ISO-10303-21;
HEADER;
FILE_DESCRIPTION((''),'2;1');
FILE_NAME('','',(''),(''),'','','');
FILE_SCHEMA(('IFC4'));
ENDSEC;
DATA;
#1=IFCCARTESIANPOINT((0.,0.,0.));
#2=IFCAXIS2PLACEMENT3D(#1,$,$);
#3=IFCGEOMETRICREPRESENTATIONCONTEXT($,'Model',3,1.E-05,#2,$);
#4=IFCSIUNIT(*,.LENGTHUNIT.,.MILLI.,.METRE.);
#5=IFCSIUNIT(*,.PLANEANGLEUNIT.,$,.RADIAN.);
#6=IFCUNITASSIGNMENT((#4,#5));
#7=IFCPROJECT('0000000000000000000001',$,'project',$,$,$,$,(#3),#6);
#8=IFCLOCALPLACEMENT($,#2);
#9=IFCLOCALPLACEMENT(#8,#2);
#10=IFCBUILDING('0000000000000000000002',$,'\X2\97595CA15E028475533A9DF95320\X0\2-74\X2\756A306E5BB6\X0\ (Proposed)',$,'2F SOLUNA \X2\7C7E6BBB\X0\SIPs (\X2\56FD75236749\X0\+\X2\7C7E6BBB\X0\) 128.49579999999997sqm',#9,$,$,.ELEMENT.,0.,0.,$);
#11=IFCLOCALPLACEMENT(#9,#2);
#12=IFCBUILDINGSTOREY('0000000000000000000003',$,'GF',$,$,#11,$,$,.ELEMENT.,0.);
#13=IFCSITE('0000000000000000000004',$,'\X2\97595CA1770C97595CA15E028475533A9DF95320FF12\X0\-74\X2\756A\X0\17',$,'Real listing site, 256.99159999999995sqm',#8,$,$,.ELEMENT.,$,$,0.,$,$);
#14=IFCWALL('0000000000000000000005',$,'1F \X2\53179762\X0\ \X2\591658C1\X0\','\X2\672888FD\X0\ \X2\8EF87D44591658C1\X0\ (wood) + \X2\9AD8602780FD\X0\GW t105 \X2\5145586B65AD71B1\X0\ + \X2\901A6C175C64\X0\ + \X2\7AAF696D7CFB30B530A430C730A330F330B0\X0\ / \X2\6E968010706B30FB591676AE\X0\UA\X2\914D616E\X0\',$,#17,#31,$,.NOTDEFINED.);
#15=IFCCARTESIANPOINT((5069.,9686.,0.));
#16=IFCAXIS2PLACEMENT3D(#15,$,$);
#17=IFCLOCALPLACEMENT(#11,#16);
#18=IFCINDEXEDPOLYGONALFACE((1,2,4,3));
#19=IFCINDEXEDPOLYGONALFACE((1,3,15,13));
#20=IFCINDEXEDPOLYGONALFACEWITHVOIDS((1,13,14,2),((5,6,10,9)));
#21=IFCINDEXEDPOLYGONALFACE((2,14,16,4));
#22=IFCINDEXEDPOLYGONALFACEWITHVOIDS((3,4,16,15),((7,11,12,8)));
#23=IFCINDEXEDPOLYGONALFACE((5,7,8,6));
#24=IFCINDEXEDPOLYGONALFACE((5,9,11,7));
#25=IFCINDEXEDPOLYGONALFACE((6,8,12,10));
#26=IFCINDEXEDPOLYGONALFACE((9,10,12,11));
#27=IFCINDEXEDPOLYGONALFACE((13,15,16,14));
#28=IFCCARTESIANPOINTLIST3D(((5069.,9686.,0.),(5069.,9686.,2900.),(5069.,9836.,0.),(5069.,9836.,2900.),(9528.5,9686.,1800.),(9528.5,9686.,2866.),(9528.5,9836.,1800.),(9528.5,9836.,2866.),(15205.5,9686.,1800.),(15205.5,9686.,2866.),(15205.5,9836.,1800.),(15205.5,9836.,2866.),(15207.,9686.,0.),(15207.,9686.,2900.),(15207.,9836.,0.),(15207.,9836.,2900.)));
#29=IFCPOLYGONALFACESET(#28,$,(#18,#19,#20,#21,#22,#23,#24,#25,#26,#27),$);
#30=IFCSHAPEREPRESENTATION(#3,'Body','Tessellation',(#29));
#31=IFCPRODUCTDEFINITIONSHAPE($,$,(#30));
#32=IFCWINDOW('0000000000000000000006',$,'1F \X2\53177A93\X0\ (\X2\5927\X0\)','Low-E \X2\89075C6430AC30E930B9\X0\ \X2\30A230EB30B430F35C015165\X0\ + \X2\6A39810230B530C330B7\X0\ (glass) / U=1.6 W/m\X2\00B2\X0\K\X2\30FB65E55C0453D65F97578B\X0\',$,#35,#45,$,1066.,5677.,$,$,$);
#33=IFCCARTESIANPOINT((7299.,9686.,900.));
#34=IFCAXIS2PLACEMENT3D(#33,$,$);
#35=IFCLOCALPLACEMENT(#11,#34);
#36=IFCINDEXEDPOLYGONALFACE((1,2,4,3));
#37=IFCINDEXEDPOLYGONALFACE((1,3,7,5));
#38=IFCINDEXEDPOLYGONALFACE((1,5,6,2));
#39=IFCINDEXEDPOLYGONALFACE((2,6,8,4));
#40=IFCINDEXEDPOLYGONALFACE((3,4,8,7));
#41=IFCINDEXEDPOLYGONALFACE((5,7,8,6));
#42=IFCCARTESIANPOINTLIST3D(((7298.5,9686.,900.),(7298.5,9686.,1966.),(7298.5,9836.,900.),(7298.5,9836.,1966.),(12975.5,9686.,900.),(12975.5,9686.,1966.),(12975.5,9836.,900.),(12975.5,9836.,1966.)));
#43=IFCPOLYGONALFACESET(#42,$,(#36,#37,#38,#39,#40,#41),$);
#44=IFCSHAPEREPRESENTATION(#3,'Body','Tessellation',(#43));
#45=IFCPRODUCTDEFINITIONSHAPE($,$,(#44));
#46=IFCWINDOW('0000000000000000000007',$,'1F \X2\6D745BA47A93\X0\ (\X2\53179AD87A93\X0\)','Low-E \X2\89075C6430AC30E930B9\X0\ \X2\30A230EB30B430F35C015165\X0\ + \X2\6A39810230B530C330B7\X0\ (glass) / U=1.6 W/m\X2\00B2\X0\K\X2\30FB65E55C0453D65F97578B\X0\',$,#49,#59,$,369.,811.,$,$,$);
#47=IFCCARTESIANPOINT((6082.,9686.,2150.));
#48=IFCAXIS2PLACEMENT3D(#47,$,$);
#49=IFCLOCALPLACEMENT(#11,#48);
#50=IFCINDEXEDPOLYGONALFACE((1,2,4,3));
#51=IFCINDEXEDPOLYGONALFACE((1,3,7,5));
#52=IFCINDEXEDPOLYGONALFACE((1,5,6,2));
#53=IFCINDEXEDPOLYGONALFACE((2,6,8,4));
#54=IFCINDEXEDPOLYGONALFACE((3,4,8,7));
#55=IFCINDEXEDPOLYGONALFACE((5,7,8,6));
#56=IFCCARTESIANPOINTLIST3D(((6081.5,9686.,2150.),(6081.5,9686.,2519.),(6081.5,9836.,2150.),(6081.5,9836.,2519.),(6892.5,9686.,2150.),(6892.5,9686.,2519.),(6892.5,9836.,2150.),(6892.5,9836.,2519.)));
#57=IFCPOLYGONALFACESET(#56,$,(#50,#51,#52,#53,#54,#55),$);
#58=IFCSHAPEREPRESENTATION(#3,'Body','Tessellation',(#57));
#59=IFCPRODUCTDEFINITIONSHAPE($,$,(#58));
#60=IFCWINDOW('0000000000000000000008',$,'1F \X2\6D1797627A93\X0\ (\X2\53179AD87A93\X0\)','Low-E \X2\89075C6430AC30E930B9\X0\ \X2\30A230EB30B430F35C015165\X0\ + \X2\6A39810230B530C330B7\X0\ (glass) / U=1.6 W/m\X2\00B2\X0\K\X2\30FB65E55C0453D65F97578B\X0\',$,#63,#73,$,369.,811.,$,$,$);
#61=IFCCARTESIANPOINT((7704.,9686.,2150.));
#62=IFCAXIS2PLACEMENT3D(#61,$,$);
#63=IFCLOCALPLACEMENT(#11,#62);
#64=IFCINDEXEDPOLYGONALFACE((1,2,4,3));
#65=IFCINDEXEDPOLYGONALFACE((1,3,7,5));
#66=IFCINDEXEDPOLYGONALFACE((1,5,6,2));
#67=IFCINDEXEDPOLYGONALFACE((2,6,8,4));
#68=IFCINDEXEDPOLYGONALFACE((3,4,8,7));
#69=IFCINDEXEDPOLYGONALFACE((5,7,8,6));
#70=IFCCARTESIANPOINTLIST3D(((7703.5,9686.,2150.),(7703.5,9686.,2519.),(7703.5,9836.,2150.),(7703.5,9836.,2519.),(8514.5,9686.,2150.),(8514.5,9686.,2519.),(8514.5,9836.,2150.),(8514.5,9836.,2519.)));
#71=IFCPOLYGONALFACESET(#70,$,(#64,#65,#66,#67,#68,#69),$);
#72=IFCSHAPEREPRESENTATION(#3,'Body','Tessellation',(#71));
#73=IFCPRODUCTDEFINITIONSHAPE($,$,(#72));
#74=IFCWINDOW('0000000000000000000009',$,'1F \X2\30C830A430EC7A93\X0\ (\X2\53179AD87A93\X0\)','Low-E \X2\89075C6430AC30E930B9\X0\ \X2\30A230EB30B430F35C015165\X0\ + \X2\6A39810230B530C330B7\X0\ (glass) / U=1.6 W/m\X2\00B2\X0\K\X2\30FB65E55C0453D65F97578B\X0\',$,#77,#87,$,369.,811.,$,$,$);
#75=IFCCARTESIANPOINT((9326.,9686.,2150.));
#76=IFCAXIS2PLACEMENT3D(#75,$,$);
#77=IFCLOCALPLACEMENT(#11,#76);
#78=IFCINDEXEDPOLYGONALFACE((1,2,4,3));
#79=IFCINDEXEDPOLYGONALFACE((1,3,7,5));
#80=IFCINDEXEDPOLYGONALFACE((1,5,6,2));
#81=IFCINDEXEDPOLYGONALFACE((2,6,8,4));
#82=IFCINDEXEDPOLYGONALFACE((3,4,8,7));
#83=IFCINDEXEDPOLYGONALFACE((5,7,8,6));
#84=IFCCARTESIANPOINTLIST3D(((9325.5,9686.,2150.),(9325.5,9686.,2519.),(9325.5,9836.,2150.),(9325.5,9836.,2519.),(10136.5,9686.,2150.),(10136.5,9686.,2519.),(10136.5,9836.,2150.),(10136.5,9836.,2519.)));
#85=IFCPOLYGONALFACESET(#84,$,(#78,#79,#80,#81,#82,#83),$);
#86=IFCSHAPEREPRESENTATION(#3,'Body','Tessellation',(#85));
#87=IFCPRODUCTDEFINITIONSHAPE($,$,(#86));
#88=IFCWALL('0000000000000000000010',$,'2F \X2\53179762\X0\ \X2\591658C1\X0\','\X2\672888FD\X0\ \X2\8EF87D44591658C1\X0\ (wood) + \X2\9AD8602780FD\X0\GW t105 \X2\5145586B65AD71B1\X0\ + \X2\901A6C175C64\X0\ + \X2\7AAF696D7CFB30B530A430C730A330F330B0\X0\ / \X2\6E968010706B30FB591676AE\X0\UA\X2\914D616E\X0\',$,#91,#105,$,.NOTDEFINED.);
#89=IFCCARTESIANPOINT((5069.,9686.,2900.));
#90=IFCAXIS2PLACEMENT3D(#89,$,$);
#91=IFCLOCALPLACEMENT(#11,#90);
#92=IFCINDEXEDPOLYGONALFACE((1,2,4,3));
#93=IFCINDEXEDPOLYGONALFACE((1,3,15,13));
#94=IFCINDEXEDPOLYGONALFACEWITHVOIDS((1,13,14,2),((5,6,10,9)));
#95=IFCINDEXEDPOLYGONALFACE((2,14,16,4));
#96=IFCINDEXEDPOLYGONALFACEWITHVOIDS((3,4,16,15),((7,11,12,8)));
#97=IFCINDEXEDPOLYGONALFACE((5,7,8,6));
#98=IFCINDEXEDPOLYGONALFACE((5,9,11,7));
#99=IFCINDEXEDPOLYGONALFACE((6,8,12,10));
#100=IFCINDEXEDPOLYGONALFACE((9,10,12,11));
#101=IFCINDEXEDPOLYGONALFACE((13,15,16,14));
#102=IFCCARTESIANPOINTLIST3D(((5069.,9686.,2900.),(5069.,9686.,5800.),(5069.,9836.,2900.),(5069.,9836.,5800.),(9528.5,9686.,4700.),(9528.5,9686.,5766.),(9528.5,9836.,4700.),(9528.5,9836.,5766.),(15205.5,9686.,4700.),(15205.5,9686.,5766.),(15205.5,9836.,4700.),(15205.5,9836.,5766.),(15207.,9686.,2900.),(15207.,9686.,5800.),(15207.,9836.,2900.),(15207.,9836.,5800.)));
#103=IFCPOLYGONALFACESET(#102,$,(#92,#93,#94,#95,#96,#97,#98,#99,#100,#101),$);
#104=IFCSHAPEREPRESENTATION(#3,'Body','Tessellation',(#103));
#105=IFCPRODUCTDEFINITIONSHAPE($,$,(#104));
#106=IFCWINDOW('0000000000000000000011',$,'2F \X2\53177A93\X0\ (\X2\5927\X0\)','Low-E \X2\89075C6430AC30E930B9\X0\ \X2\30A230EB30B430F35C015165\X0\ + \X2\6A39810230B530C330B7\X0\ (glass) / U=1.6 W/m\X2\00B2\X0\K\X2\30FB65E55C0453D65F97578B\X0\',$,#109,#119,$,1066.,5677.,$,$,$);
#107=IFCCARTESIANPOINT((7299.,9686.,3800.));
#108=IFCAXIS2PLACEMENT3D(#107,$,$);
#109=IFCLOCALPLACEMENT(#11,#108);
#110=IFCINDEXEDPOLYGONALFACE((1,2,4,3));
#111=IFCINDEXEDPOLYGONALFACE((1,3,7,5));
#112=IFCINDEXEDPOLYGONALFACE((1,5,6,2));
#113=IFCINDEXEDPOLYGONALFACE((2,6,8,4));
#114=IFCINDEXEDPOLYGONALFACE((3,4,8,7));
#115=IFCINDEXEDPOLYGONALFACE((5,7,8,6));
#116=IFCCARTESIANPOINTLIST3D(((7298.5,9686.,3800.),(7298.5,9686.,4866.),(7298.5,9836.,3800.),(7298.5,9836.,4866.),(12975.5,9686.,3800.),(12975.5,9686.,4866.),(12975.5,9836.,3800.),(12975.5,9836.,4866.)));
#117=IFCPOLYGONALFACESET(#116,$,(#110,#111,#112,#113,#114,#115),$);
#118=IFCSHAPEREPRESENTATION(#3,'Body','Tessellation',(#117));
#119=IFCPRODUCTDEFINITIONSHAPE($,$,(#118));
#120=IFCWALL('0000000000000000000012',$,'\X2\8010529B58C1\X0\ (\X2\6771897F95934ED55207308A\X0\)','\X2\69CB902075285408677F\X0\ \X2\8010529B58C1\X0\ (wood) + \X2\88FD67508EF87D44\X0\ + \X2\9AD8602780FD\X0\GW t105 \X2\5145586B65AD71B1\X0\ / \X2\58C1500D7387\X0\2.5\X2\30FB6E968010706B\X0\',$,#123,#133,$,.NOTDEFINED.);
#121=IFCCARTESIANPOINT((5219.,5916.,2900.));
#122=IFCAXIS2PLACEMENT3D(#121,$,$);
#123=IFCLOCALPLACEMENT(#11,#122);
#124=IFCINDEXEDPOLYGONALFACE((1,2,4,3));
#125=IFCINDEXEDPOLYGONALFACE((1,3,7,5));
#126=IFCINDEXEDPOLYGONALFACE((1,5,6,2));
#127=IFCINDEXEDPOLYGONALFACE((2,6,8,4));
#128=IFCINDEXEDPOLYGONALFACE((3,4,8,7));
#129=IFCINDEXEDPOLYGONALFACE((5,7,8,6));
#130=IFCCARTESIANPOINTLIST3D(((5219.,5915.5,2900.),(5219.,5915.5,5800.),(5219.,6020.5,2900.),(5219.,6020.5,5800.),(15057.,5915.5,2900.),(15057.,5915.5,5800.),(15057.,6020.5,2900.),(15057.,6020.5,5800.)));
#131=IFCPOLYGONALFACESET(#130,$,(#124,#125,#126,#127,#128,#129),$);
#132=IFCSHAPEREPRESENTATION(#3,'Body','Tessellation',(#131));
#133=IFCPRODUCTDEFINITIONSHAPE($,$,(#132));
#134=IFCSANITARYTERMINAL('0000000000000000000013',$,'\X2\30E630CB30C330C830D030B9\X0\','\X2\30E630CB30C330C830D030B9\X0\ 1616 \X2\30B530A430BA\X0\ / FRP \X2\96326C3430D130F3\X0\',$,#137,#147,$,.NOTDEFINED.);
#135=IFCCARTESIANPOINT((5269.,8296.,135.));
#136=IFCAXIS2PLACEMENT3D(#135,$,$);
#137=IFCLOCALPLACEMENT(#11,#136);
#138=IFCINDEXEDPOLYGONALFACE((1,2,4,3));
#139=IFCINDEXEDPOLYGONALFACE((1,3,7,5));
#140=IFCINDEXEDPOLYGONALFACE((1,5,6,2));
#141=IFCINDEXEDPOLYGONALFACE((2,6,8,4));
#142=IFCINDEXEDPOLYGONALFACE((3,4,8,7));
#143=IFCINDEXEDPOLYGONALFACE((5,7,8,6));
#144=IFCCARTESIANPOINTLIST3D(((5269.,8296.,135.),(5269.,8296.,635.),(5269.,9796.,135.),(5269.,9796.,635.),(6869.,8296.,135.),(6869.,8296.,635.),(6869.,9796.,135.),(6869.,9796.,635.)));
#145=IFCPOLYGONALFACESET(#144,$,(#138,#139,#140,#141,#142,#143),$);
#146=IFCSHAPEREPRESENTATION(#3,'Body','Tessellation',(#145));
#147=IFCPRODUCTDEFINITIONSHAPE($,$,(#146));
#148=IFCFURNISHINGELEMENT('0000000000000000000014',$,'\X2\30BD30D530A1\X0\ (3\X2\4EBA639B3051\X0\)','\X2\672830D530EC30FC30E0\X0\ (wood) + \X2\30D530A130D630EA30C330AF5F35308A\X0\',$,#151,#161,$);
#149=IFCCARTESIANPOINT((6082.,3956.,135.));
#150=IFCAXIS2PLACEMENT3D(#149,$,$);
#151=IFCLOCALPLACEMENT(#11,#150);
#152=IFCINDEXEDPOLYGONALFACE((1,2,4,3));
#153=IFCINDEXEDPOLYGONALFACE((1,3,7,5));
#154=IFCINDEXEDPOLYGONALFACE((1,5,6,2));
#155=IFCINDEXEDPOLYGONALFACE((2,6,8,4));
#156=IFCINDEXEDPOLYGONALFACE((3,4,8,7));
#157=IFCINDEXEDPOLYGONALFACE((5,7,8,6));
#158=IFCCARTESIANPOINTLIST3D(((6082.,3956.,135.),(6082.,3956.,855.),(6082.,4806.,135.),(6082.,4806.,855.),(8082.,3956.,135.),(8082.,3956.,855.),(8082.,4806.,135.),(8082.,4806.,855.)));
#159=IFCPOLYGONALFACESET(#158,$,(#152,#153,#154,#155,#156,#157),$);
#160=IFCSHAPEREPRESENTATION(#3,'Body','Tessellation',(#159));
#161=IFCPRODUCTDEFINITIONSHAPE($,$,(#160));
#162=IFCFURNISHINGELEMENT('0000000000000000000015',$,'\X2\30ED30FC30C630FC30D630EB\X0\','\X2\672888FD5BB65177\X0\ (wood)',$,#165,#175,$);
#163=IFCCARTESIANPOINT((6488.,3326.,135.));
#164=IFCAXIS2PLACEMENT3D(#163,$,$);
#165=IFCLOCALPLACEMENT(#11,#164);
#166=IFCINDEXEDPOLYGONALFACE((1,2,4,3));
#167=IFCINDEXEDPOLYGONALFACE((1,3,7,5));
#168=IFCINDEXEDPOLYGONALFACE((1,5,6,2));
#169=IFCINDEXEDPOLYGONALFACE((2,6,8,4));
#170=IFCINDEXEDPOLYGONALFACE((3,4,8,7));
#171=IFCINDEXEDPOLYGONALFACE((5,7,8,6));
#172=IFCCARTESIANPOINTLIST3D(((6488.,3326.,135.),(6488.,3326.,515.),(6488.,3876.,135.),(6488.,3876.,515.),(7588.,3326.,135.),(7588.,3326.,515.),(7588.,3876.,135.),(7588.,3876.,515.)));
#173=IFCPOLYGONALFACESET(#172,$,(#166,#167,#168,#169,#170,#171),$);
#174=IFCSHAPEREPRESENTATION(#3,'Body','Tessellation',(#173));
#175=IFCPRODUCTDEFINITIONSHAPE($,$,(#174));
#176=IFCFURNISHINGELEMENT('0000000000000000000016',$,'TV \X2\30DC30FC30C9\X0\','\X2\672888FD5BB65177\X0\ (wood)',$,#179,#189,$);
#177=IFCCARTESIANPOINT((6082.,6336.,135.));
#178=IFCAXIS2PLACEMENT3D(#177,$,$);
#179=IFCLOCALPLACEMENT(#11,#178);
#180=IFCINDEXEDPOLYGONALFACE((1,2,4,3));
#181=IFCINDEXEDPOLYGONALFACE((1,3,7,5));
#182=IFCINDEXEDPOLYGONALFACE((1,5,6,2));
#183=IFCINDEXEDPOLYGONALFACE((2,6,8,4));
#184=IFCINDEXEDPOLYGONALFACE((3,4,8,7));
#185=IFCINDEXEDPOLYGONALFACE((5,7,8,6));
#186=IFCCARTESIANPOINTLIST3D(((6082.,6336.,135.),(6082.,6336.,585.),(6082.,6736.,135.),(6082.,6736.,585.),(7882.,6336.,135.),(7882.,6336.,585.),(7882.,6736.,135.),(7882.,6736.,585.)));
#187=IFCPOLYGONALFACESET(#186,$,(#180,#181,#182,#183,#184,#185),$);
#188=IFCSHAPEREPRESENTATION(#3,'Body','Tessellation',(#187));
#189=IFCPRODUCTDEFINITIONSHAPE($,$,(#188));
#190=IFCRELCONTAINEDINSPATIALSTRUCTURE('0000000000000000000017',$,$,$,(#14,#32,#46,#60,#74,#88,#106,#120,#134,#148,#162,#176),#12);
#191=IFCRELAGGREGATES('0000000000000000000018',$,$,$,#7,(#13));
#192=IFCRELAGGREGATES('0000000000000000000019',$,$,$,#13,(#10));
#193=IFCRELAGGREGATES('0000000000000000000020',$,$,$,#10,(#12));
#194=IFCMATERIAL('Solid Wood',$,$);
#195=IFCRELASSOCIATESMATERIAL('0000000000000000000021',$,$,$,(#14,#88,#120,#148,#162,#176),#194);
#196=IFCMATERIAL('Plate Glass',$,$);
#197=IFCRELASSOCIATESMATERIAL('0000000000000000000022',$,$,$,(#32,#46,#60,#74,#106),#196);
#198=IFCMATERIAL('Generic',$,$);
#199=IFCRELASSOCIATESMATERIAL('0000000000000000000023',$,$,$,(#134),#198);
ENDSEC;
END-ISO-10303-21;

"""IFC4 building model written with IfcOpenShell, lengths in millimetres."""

from ifc_helpers import new_model, si_unit, frame, frame_2d, origin, place, context, project, spatial, rectangle, extrude, material, element, fill, save


model = new_model("IFC4")

# Units and contexts
model_context = context("Model", 3, precision=1e-05, world=origin())
ifc_project = project(units=[si_unit("LENGTHUNIT", "METRE", prefix="MILLI"), si_unit("PLANEANGLEUNIT", "RADIAN")], contexts=[model_context])

# Site, building, storey
site_placement = place(None, origin())
site = spatial("IfcSite", under=ifc_project, at=site_placement, Name="静岡県静岡市葵区鷹匠２-74番17", ObjectType="Real listing site, 256.99159999999995sqm", CompositionType="ELEMENT", RefElevation=0.0)
building_placement = place(site_placement, origin())
building = spatial("IfcBuilding", under=site, at=building_placement, Name="静岡市葵区鷹匠2-74番の家 (Proposed)", ObjectType="2F SOLUNA 籾殻SIPs (国産杉+籾殻) 128.49579999999997sqm", CompositionType="ELEMENT", ElevationOfRefHeight=0.0, ElevationOfTerrain=0.0)
storey_placement = place(building_placement, origin())
storey = spatial("IfcBuildingStorey", under=building, at=storey_placement, Name="GF", CompositionType="ELEMENT", Elevation=0.0)

# Wall, openings, windows
ifc_material_1 = material(Name="Solid Wood")
wall_1_placement = place(storey_placement, frame((5069.0, 9686.0, 0.0)))
wall_1 = element("IfcWall", 1, at=wall_1_placement, inside=storey, material=ifc_material_1, Name="1F 北面 外壁", Description="木製 軸組外壁 (wood) + 高性能GW t105 充填断熱 + 通気層 + 窯業系サイディング / 準耐火・外皮UA配慮", PredefinedType="NOTDEFINED", context=model_context, shape_type="SweptSolid", body=[
    extrude(rectangle(XDim=10138.0, YDim=150.0, at=frame_2d((5069.0, 75.0))), frame((5069.0, 9686.0, 0.0)), (0.0, 0.0, 1.0), 2900.0),
])
opening_1_placement = place(storey_placement, frame((7299.0, 9686.0, 900.0)))
opening_1 = element("IfcOpeningElement", 2, at=opening_1_placement, cuts=wall_1, PredefinedType="NOTDEFINED", context=model_context, shape_type="SweptSolid", body=[
    extrude(rectangle(XDim=5677.0, YDim=150.0, at=frame_2d((2838.0, 75.0))), frame((7299.0, 9686.0, 900.0)), (0.0, 0.0, 1.0), 1066.0),
])
opening_2_placement = place(storey_placement, frame((6082.0, 9686.0, 2150.0)))
opening_2 = element("IfcOpeningElement", 3, at=opening_2_placement, cuts=wall_1, PredefinedType="NOTDEFINED", context=model_context, shape_type="SweptSolid", body=[
    extrude(rectangle(XDim=811.0, YDim=150.0, at=frame_2d((405.0, 75.0))), frame((6082.0, 9686.0, 2150.0)), (0.0, 0.0, 1.0), 369.0),
])
opening_3_placement = place(storey_placement, frame((7704.0, 9686.0, 2150.0)))
opening_3 = element("IfcOpeningElement", 4, at=opening_3_placement, cuts=wall_1, PredefinedType="NOTDEFINED", context=model_context, shape_type="SweptSolid", body=[
    extrude(rectangle(XDim=811.0, YDim=150.0, at=frame_2d((405.0, 75.0))), frame((7704.0, 9686.0, 2150.0)), (0.0, 0.0, 1.0), 369.0),
])
opening_4_placement = place(storey_placement, frame((9326.0, 9686.0, 2150.0)))
opening_4 = element("IfcOpeningElement", 5, at=opening_4_placement, cuts=wall_1, PredefinedType="NOTDEFINED", context=model_context, shape_type="SweptSolid", body=[
    extrude(rectangle(XDim=811.0, YDim=150.0, at=frame_2d((405.0, 75.0))), frame((9326.0, 9686.0, 2150.0)), (0.0, 0.0, 1.0), 369.0),
])
ifc_material_2 = material(Name="Plate Glass")
window_1_placement = place(storey_placement, frame((7299.0, 9686.0, 900.0)))
window_1 = element("IfcWindow", 6, at=window_1_placement, inside=storey, material=ifc_material_2, Name="1F 北窓 (大)", Description="Low-E 複層ガラス アルゴン封入 + 樹脂サッシ (glass) / U=1.6 W/m²K・日射取得型", OverallHeight=1066.0, OverallWidth=5677.0, context=model_context, shape_type="SweptSolid", body=[
    extrude(rectangle(XDim=5677.0, YDim=150.0, at=frame_2d((2838.0, 75.0))), frame((7299.0, 9686.0, 900.0)), (0.0, 0.0, 1.0), 1066.0),
])
fill(opening_1, window_1)
window_2_placement = place(storey_placement, frame((6082.0, 9686.0, 2150.0)))
window_2 = element("IfcWindow", 7, at=window_2_placement, inside=storey, material=ifc_material_2, Name="1F 浴室窓 (北高窓)", Description="Low-E 複層ガラス アルゴン封入 + 樹脂サッシ (glass) / U=1.6 W/m²K・日射取得型", OverallHeight=369.0, OverallWidth=811.0, context=model_context, shape_type="SweptSolid", body=[
    extrude(rectangle(XDim=811.0, YDim=150.0, at=frame_2d((405.0, 75.0))), frame((6082.0, 9686.0, 2150.0)), (0.0, 0.0, 1.0), 369.0),
])
fill(opening_2, window_2)
window_3_placement = place(storey_placement, frame((7704.0, 9686.0, 2150.0)))
window_3 = element("IfcWindow", 8, at=window_3_placement, inside=storey, material=ifc_material_2, Name="1F 洗面窓 (北高窓)", Description="Low-E 複層ガラス アルゴン封入 + 樹脂サッシ (glass) / U=1.6 W/m²K・日射取得型", OverallHeight=369.0, OverallWidth=811.0, context=model_context, shape_type="SweptSolid", body=[
    extrude(rectangle(XDim=811.0, YDim=150.0, at=frame_2d((405.0, 75.0))), frame((7704.0, 9686.0, 2150.0)), (0.0, 0.0, 1.0), 369.0),
])
fill(opening_3, window_3)
window_4_placement = place(storey_placement, frame((9326.0, 9686.0, 2150.0)))
window_4 = element("IfcWindow", 9, at=window_4_placement, inside=storey, material=ifc_material_2, Name="1F トイレ窓 (北高窓)", Description="Low-E 複層ガラス アルゴン封入 + 樹脂サッシ (glass) / U=1.6 W/m²K・日射取得型", OverallHeight=369.0, OverallWidth=811.0, context=model_context, shape_type="SweptSolid", body=[
    extrude(rectangle(XDim=811.0, YDim=150.0, at=frame_2d((405.0, 75.0))), frame((9326.0, 9686.0, 2150.0)), (0.0, 0.0, 1.0), 369.0),
])
fill(opening_4, window_4)

# Wall, opening, window
wall_2_placement = place(storey_placement, frame((5069.0, 9686.0, 2900.0)))
wall_2 = element("IfcWall", 10, at=wall_2_placement, inside=storey, material=ifc_material_1, Name="2F 北面 外壁", Description="木製 軸組外壁 (wood) + 高性能GW t105 充填断熱 + 通気層 + 窯業系サイディング / 準耐火・外皮UA配慮", PredefinedType="NOTDEFINED", context=model_context, shape_type="SweptSolid", body=[
    extrude(rectangle(XDim=10138.0, YDim=150.0, at=frame_2d((5069.0, 75.0))), frame((5069.0, 9686.0, 2900.0)), (0.0, 0.0, 1.0), 2900.0),
])
opening_5_placement = place(storey_placement, frame((7299.0, 9686.0, 3800.0)))
opening_5 = element("IfcOpeningElement", 11, at=opening_5_placement, cuts=wall_2, PredefinedType="NOTDEFINED", context=model_context, shape_type="SweptSolid", body=[
    extrude(rectangle(XDim=5677.0, YDim=150.0, at=frame_2d((2838.0, 75.0))), frame((7299.0, 9686.0, 3800.0)), (0.0, 0.0, 1.0), 1066.0),
])
window_5_placement = place(storey_placement, frame((7299.0, 9686.0, 3800.0)))
window_5 = element("IfcWindow", 12, at=window_5_placement, inside=storey, material=ifc_material_2, Name="2F 北窓 (大)", Description="Low-E 複層ガラス アルゴン封入 + 樹脂サッシ (glass) / U=1.6 W/m²K・日射取得型", OverallHeight=1066.0, OverallWidth=5677.0, context=model_context, shape_type="SweptSolid", body=[
    extrude(rectangle(XDim=5677.0, YDim=150.0, at=frame_2d((2838.0, 75.0))), frame((7299.0, 9686.0, 3800.0)), (0.0, 0.0, 1.0), 1066.0),
])
fill(opening_5, window_5)

# Wall
wall_3_placement = place(storey_placement, frame((5219.0, 5916.0, 2900.0)))
element("IfcWall", 13, at=wall_3_placement, inside=storey, material=ifc_material_1, Name="耐力壁 (東西間仕切り)", Description="構造用合板 耐力壁 (wood) + 製材軸組 + 高性能GW t105 充填断熱 / 壁倍率2.5・準耐火", PredefinedType="NOTDEFINED", context=model_context, shape_type="SweptSolid", body=[
    extrude(rectangle(XDim=9838.0, YDim=105.0, at=frame_2d((4919.0, 52.0))), frame((5219.0, 5916.0, 2900.0)), (0.0, 0.0, 1.0), 2900.0),
])

# Sanitary terminal
ifc_material_3 = material(Name="Generic")
sanitary_terminal_placement = place(storey_placement, frame((5269.0, 8296.0, 135.0)))
element("IfcSanitaryTerminal", 14, at=sanitary_terminal_placement, inside=storey, material=ifc_material_3, Name="ユニットバス", Description="ユニットバス 1616 サイズ / FRP 防水パン", PredefinedType="NOTDEFINED", context=model_context, shape_type="SweptSolid", body=[
    extrude(rectangle(XDim=1600.0, YDim=1500.0, at=frame_2d((800.0, 750.0))), frame((5269.0, 8296.0, 135.0)), (0.0, 0.0, 1.0), 500.0),
])

# Furnishing elements
furnishing_1_placement = place(storey_placement, frame((6082.0, 3956.0, 135.0)))
element("IfcFurnishingElement", 15, at=furnishing_1_placement, inside=storey, material=ifc_material_1, Name="ソファ (3人掛け)", Description="木フレーム (wood) + ファブリック張り", context=model_context, shape_type="SweptSolid", body=[
    extrude(rectangle(XDim=2000.0, YDim=850.0, at=frame_2d((1000.0, 425.0))), frame((6082.0, 3956.0, 135.0)), (0.0, 0.0, 1.0), 720.0),
])
furnishing_2_placement = place(storey_placement, frame((6488.0, 3326.0, 135.0)))
element("IfcFurnishingElement", 16, at=furnishing_2_placement, inside=storey, material=ifc_material_1, Name="ローテーブル", Description="木製家具 (wood)", context=model_context, shape_type="SweptSolid", body=[
    extrude(rectangle(XDim=1100.0, YDim=550.0, at=frame_2d((550.0, 275.0))), frame((6488.0, 3326.0, 135.0)), (0.0, 0.0, 1.0), 380.0),
])
furnishing_3_placement = place(storey_placement, frame((6082.0, 6336.0, 135.0)))
element("IfcFurnishingElement", 17, at=furnishing_3_placement, inside=storey, material=ifc_material_1, Name="TV ボード", Description="木製家具 (wood)", context=model_context, shape_type="SweptSolid", body=[
    extrude(rectangle(XDim=1800.0, YDim=400.0, at=frame_2d((900.0, 200.0))), frame((6082.0, 6336.0, 135.0)), (0.0, 0.0, 1.0), 450.0),
])

save(model, "model.ifc")
